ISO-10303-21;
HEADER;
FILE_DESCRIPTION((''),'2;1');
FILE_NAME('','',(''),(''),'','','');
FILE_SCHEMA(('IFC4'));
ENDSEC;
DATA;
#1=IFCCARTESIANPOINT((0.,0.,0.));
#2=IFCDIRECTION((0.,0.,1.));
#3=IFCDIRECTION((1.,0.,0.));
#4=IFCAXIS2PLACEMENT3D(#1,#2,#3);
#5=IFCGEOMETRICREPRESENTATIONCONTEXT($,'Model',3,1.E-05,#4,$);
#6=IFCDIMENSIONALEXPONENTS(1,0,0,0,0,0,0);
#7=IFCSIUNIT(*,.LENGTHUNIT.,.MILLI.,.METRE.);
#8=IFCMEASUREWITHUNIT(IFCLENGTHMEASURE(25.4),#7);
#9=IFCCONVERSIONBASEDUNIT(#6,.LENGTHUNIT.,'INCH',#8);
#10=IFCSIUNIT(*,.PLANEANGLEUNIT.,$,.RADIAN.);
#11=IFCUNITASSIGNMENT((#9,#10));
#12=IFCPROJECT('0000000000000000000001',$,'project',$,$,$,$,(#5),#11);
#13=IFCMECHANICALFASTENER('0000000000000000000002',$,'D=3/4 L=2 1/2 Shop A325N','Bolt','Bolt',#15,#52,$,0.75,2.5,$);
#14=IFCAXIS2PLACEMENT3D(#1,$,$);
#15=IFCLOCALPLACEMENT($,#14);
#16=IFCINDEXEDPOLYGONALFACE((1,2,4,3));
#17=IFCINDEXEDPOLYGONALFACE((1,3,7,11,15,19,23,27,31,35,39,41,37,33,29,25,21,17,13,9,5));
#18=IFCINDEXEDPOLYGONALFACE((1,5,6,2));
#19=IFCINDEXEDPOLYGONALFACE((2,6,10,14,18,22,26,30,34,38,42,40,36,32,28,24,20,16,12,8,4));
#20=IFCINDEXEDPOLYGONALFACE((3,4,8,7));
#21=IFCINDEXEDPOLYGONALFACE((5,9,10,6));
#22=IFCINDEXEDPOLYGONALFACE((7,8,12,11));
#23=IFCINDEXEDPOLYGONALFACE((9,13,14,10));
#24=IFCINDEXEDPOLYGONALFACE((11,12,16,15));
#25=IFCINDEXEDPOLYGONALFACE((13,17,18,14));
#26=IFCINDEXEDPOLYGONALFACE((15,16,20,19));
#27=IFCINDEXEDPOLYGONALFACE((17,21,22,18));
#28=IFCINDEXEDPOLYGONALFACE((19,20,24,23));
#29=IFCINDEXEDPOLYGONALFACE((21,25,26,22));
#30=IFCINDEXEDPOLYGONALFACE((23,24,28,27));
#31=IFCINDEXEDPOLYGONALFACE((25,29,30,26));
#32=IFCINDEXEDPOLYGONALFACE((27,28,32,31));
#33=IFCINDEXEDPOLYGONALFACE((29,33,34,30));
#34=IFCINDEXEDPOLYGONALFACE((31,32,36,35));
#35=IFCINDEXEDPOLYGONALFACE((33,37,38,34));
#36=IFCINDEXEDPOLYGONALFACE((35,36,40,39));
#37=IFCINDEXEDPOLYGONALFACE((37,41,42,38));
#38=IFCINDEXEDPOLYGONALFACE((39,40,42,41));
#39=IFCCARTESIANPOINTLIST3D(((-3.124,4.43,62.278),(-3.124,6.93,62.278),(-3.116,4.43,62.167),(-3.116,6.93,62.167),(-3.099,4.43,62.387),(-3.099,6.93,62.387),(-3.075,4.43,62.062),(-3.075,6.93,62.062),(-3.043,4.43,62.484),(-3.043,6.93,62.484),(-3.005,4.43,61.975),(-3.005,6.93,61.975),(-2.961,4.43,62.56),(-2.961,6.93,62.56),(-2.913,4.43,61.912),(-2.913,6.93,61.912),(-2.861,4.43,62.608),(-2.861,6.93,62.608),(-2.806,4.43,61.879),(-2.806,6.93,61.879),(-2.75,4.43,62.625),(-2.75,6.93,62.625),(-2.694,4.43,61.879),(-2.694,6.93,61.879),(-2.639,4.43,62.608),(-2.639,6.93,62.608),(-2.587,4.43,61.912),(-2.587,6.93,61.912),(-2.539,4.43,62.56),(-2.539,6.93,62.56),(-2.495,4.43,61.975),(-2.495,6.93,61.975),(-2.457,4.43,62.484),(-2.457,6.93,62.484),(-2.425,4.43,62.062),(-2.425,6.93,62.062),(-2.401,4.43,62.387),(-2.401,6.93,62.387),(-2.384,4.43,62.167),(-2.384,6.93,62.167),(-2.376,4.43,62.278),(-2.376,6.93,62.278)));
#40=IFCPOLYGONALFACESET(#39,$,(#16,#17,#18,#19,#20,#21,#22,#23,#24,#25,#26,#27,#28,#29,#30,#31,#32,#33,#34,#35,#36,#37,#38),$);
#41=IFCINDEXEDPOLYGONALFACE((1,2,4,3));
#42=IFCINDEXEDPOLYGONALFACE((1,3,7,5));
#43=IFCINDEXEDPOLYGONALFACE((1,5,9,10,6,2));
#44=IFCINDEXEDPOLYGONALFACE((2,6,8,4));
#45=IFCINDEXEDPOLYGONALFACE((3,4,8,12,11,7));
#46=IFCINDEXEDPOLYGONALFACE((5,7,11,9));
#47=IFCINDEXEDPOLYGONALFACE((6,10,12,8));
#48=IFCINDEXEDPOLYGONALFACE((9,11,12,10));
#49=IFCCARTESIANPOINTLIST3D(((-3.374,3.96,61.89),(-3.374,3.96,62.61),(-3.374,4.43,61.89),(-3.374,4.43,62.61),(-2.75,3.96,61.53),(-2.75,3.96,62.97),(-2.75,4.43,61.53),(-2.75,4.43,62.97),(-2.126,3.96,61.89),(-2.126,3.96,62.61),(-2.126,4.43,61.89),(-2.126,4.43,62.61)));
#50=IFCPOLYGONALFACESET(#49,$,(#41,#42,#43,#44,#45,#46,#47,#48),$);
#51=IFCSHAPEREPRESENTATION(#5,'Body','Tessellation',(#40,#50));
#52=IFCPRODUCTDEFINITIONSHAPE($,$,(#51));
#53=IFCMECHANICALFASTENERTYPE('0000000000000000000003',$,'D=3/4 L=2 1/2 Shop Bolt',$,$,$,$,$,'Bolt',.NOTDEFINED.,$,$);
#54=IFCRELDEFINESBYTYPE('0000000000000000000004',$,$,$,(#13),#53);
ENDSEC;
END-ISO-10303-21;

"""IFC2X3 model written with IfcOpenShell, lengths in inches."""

from ifc_helpers import new_model, entity, si_unit, converted_unit, frame, origin_with_axes, origin_2d_with_axis, place, context, project, polyline, circle, outline, extrude, source, transform, mapped, type_object, type_shapes, element, save


model = new_model("IFC2X3")

# Units and contexts
model_context = context("Model", 3, precision=1e-05, world=origin_with_axes())
ifc_project = project(units=[converted_unit("LENGTHUNIT", "INCH", entity("IfcLengthMeasure", 25.4), si_unit("LENGTHUNIT", "METRE", prefix="MILLI"), dimensions=[1, 0, 0, 0, 0, 0, 0]), si_unit("PLANEANGLEUNIT", "RADIAN")], contexts=[model_context])

# Mechanical fastener
placement_1 = place(None, origin_with_axes())
placement_2 = place(placement_1, origin_with_axes())
placement_3 = place(placement_2, frame((0.0, 0.0, 54.5), z_axis=(0.0, -1.0, 0.0), x_axis=(0.0, 0.0, 1.0)))
mechanical_fastener_type_1 = type_object("IfcMechanicalFastenerType", Name="D=3/4 L=2 1/2 Shop Bolt", ElementType="Bolt")
shared_shape_1 = source(origin_with_axes(), model_context, "Body", "SweptSolid", [
    extrude(circle(Radius=0.375, at=origin_2d_with_axis()), frame((0.0, 0.0, 0.0), z_axis=(1.0, 0.0, 0.0), x_axis=(0.0, 1.0, 0.0)), (0.0, 0.0, 1.0), 2.5),
    extrude(outline(polyline([(-0.72, 0.0), (-0.36, 0.624), (0.36, 0.624), (0.72, 0.0), (0.36, -0.624), (-0.36, -0.624), (-0.72, 0.0)])), frame((0.0, 0.0, 0.0), z_axis=(1.0, 0.0, 0.0), x_axis=(0.0, 1.0, 0.0)), (0.0, 0.0, -1.0), 0.47),
])
type_shapes(mechanical_fastener_type_1, [shared_shape_1])
placement_4 = place(placement_3, frame((7.75, 2.75, -4.43), z_axis=(0.0, -1.0, 0.0), x_axis=(0.0, 0.0, -1.0)))
mechanical_fastener_1_placement = place(placement_4, origin_with_axes())
element("IfcMechanicalFastener", 1, at=mechanical_fastener_1_placement, type_object=mechanical_fastener_type_1, Name="D=3/4 L=2 1/2 Shop A325N", Description="Bolt", ObjectType="Bolt", NominalDiameter=0.75, NominalLength=2.5, context=model_context, shape_type="MappedRepresentation", body=[
    mapped(shared_shape_1, transform((0.0, 0.0, 0.0), scale=1.0)),
])

save(model, "model.ifc")
